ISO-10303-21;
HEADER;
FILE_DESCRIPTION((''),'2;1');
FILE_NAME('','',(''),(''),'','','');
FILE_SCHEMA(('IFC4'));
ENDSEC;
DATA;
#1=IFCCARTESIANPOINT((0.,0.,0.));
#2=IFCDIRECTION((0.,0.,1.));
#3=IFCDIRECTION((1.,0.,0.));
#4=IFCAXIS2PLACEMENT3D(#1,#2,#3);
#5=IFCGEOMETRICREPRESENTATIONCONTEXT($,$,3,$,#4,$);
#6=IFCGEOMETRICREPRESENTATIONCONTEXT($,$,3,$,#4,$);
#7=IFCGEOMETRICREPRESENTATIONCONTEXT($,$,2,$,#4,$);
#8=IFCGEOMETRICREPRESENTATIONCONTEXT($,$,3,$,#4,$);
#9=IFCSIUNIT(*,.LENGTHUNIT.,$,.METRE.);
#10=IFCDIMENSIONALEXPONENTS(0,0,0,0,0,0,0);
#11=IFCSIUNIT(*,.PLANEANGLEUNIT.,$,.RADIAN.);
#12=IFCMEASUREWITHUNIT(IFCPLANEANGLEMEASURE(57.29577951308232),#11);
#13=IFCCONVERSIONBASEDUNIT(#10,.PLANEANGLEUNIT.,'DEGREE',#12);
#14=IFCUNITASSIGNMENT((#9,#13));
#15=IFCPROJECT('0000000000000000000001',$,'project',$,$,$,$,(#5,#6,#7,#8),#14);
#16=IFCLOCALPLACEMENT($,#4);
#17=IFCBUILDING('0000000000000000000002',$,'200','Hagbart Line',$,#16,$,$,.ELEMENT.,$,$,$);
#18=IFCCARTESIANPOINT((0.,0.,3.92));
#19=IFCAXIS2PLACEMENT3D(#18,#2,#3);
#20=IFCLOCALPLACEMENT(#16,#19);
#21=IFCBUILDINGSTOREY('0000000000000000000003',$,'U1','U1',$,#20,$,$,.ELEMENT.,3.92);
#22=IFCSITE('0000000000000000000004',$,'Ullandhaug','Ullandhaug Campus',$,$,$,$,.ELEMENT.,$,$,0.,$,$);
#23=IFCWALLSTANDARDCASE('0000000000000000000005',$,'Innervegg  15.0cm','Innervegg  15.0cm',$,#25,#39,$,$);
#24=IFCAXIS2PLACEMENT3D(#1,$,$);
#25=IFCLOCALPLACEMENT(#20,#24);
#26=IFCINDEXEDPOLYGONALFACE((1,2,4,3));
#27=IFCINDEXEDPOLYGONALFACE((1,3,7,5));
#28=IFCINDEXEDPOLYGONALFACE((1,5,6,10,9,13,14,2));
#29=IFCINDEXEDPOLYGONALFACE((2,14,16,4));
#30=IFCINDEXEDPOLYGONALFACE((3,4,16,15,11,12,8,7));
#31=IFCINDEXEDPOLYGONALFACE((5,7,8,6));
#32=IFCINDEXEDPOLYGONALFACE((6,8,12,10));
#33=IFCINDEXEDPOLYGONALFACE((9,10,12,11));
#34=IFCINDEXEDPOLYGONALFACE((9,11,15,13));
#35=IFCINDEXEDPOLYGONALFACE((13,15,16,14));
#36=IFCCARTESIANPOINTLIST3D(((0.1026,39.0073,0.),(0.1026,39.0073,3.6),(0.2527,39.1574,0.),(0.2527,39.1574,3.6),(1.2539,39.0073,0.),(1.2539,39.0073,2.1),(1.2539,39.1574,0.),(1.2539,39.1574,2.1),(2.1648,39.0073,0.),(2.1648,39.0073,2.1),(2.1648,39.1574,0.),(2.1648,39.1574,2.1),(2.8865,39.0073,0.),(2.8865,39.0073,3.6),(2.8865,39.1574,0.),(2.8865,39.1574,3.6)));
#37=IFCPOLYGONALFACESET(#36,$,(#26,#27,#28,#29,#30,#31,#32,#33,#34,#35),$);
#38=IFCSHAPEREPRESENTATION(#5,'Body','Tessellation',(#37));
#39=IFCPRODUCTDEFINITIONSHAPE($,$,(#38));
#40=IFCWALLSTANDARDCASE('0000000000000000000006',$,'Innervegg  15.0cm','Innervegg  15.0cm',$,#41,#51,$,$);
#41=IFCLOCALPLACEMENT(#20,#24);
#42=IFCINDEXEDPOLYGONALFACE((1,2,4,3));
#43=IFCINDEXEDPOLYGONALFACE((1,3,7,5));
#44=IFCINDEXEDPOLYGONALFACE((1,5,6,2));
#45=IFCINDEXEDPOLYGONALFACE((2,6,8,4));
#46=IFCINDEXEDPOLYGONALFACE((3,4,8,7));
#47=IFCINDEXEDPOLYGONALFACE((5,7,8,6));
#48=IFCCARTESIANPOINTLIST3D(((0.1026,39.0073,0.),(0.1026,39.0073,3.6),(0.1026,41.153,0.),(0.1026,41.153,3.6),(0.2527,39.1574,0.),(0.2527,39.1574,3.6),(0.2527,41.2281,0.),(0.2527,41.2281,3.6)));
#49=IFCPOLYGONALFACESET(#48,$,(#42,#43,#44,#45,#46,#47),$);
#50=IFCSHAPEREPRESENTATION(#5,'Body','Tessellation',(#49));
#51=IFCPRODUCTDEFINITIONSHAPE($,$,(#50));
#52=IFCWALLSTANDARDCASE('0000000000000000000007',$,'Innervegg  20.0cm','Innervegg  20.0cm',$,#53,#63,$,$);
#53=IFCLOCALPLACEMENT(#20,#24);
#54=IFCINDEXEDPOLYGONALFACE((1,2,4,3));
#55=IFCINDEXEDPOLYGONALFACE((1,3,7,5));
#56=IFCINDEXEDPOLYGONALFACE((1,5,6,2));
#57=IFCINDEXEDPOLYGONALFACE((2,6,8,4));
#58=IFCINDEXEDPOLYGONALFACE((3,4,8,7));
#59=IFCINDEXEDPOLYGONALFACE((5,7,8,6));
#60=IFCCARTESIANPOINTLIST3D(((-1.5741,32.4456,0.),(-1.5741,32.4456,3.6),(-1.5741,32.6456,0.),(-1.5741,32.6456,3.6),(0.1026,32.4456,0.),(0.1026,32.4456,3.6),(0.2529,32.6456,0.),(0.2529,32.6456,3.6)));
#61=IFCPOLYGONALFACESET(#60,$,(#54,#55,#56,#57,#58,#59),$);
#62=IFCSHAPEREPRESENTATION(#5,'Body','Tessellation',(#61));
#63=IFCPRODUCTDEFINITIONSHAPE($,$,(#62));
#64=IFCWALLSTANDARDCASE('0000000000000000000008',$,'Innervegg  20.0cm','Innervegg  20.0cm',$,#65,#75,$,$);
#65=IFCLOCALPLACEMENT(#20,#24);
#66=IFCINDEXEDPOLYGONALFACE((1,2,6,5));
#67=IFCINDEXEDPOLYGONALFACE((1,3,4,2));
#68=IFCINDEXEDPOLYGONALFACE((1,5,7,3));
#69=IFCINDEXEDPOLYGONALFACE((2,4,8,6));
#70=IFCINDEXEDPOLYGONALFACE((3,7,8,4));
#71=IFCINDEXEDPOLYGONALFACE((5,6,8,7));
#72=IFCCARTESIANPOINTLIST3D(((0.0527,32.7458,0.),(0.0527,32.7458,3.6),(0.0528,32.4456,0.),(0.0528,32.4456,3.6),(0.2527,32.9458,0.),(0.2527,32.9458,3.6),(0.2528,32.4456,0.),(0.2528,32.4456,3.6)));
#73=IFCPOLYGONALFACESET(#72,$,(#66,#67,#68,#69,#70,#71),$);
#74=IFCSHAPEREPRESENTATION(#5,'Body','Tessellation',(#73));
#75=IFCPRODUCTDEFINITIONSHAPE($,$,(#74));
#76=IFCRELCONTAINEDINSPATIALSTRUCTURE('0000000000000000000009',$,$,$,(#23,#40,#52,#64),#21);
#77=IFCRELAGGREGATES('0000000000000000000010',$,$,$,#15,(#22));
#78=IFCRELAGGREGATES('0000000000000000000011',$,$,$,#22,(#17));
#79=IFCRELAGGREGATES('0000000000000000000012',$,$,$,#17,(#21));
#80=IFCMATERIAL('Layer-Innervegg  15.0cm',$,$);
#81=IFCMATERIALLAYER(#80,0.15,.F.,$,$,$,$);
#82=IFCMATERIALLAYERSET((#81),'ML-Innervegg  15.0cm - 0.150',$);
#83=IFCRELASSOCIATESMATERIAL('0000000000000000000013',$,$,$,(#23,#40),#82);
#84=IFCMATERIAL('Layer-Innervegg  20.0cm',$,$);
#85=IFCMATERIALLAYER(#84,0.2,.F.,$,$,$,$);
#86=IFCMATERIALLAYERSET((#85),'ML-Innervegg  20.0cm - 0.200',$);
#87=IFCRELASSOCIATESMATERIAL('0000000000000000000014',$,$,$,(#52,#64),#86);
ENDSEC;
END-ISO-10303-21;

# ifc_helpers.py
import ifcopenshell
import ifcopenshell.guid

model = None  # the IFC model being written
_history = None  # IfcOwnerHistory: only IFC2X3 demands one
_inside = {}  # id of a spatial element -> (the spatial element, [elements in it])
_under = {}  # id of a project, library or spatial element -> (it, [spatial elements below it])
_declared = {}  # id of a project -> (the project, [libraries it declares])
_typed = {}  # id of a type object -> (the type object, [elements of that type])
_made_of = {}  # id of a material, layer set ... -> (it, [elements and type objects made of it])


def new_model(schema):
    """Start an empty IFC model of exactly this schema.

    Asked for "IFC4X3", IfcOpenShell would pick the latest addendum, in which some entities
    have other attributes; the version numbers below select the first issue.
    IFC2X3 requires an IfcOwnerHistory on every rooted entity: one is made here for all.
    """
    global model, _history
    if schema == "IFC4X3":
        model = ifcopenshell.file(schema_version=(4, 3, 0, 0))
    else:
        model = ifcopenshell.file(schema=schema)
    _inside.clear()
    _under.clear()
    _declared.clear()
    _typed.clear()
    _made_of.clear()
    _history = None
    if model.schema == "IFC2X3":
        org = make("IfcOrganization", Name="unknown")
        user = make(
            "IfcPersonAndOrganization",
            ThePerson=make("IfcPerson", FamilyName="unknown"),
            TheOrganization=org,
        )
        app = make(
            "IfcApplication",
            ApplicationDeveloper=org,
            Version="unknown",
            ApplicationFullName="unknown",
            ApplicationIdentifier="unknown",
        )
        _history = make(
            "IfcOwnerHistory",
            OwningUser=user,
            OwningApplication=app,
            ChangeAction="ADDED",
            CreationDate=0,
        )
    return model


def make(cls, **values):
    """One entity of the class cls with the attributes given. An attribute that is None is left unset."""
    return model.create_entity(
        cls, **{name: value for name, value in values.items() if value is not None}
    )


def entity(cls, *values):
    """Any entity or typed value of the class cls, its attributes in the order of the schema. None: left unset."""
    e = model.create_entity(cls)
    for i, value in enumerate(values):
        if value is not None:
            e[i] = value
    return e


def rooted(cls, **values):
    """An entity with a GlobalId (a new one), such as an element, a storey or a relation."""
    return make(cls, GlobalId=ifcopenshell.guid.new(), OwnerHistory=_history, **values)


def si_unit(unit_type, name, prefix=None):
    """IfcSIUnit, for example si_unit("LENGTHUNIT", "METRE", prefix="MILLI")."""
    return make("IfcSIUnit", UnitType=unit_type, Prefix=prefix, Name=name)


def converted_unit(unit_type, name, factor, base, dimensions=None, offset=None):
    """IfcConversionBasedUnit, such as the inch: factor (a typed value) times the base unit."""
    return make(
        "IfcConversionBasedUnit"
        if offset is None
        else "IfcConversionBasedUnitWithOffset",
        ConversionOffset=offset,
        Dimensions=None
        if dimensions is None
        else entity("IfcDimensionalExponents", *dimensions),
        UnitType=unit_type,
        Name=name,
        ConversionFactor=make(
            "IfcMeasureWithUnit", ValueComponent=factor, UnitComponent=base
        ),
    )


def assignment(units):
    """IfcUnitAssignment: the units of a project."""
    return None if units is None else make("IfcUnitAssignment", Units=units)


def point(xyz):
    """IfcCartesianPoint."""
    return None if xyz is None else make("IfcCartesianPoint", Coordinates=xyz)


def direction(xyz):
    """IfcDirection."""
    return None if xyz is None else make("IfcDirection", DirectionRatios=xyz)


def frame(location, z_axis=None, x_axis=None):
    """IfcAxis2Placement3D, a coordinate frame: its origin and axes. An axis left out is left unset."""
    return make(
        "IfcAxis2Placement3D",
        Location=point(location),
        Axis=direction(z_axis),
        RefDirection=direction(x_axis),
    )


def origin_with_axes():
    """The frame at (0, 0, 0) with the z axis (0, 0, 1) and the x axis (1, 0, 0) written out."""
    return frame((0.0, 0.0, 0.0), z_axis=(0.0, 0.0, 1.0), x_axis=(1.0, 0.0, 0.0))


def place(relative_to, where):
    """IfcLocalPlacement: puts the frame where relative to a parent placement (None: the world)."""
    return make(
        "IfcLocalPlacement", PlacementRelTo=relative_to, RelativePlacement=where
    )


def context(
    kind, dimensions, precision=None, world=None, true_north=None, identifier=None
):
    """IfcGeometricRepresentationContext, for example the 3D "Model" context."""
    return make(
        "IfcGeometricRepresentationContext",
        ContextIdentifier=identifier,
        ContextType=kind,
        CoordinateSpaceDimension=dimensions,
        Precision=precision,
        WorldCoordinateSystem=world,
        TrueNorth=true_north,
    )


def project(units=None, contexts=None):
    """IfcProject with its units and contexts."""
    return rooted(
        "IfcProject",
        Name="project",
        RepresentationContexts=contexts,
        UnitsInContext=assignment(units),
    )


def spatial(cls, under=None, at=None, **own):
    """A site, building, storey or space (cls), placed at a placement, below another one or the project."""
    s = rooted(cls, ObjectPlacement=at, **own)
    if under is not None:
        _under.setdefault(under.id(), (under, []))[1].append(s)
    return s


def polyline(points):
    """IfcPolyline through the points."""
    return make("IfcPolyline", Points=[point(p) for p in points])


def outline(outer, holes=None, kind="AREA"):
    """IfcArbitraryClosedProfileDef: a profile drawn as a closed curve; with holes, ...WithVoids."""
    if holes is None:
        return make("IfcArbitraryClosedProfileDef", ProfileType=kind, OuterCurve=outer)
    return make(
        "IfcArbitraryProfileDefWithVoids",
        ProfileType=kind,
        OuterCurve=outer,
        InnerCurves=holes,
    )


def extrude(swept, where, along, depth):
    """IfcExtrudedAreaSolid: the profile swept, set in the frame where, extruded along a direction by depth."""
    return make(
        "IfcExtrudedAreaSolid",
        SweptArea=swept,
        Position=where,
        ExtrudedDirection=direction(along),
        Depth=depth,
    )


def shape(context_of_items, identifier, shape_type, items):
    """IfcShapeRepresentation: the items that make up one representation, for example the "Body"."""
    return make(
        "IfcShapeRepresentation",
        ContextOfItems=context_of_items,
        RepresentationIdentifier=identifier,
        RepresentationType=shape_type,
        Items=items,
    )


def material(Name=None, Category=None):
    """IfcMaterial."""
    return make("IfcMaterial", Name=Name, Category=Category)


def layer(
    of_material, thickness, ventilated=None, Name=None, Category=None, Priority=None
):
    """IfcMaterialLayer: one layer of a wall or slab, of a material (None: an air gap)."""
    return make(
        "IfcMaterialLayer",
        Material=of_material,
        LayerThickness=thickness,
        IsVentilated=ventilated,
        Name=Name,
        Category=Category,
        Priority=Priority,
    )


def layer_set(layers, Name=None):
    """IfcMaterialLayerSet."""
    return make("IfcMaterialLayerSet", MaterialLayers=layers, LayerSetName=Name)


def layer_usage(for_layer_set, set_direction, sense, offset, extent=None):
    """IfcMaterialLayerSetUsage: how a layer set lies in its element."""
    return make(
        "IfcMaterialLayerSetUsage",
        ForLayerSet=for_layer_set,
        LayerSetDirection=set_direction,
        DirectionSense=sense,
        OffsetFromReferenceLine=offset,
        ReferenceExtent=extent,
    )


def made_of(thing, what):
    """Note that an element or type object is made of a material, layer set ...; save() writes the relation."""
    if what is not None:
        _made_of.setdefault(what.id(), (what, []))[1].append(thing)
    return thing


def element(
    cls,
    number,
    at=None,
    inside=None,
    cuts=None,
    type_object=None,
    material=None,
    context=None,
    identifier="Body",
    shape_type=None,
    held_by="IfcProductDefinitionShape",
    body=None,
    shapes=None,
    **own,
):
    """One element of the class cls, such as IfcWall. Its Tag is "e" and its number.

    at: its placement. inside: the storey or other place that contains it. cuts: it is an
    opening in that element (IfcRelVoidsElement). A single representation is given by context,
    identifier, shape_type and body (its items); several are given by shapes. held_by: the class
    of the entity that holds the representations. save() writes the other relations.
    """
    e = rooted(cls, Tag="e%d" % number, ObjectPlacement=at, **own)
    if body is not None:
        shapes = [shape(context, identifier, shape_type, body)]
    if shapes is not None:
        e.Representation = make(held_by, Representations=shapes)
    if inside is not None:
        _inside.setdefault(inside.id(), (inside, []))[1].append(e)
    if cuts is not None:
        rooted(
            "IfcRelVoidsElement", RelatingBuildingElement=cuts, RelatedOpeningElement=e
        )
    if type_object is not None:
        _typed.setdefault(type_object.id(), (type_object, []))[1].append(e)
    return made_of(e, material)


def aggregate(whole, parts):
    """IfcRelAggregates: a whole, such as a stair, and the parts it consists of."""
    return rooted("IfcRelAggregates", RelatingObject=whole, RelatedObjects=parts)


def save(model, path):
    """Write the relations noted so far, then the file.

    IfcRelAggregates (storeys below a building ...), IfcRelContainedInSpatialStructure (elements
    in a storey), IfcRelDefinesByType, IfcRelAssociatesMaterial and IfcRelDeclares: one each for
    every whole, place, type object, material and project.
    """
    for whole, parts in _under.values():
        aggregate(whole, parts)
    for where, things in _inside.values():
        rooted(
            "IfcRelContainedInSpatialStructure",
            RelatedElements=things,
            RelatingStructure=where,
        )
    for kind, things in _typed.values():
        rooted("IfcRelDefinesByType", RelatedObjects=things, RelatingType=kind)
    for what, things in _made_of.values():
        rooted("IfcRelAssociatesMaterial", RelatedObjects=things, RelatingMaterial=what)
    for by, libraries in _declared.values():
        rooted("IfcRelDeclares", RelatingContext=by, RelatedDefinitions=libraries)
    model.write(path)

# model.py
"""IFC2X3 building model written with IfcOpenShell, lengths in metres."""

from ifc_helpers import new_model, entity, si_unit, converted_unit, frame, origin_with_axes, place, context, project, spatial, polyline, outline, extrude, material, layer, layer_set, layer_usage, element, save


model = new_model("IFC2X3")

# Units and contexts
context_of_model_1 = context(None, 3, world=origin_with_axes())
context_of_model_2 = context(None, 3, world=origin_with_axes())
context_of_model_3 = context(None, 2, world=origin_with_axes())
context_of_model_4 = context(None, 3, world=origin_with_axes())
ifc_project = project(units=[si_unit("LENGTHUNIT", "METRE"), converted_unit("PLANEANGLEUNIT", "DEGREE", entity("IfcPlaneAngleMeasure", 57.29577951308232), si_unit("PLANEANGLEUNIT", "RADIAN"), dimensions=[0, 0, 0, 0, 0, 0, 0])], contexts=[context_of_model_1, context_of_model_2, context_of_model_3, context_of_model_4])

# Site, building, storey
site = spatial("IfcSite", under=ifc_project, Name="Ullandhaug", Description="Ullandhaug Campus", CompositionType="ELEMENT", RefElevation=0.0)
building_placement = place(None, origin_with_axes())
building = spatial("IfcBuilding", under=site, at=building_placement, Name="200", Description="Hagbart Line", CompositionType="ELEMENT")
storey_placement = place(building_placement, frame((0.0, 0.0, 3.92), z_axis=(0.0, 0.0, 1.0), x_axis=(1.0, 0.0, 0.0)))
storey = spatial("IfcBuildingStorey", under=building, at=storey_placement, Name="U1", Description="U1", CompositionType="ELEMENT", Elevation=3.92)

# Shared definitions
ifc_material_1 = material(Name="Layer-Innervegg  15.0cm")
ifc_layer_1 = layer(ifc_material_1, 0.15, ventilated=False)
ifc_layer_set_1 = layer_set([ifc_layer_1], Name="ML-Innervegg  15.0cm - 0.150")
ifc_layer_usage_1 = layer_usage(ifc_layer_set_1, "AXIS2", "POSITIVE", 0.0)

# Wall, opening
wall_1_placement = place(storey_placement, frame((0.1026, 39.0073, 0.0), z_axis=(0.0, 0.0, 1.0), x_axis=(1.0, 0.0, 0.0)))
wall_1 = element("IfcWallStandardCase", 1, at=wall_1_placement, inside=storey, material=ifc_layer_usage_1, Name="Innervegg  15.0cm", Description="Innervegg  15.0cm", context=context_of_model_1, shape_type="SweptSolid", body=[
    extrude(outline(polyline([(0.0, 0.0), (2.7839, 0.0), (2.7839, 0.1502), (0.1502, 0.1502), (0.0, 0.0)])), origin_with_axes(), (0.0, 0.0, 1.0), 3.6),
])
opening_1_placement = place(wall_1_placement, frame((1.1513, 0.1502, 0.0), z_axis=(0.0, 0.0, 1.0), x_axis=(1.0, 0.0, 0.0)))
element("IfcOpeningElement", 2, at=opening_1_placement, cuts=wall_1, context=context_of_model_1, shape_type="SweptSolid", body=[
    extrude(outline(polyline([(0.0, 0.0), (2.1, 0.0), (2.1, 0.9109), (0.0, 0.9109), (0.0, 0.0)])), frame((0.0, 0.0, 0.0), z_axis=(0.0, 1.0, 0.0), x_axis=(0.0, 0.0, 1.0)), (0.0, 0.0, -1.0), 0.1502),
])

# Walls
wall_2_placement = place(storey_placement, frame((0.1026, 41.153, 0.0), z_axis=(0.0, 0.0, 1.0), x_axis=(0.0, -1.0, 0.0)))
element("IfcWallStandardCase", 3, at=wall_2_placement, inside=storey, material=ifc_layer_usage_1, Name="Innervegg  15.0cm", Description="Innervegg  15.0cm", context=context_of_model_1, shape_type="SweptSolid", body=[
    extrude(outline(polyline([(0.0, 0.0), (2.1457, 0.0), (1.9956, 0.1502), (-0.0751, 0.1502), (0.0, 0.0)])), frame((0.0, 0.0, 0.0), z_axis=(0.0, 0.0, 1.0), x_axis=(1.0, 0.0, 0.0)), (0.0, 0.0, 1.0), 3.6),
])
ifc_material_2 = material(Name="Layer-Innervegg  20.0cm")
ifc_layer_2 = layer(ifc_material_2, 0.2, ventilated=False)
ifc_layer_set_2 = layer_set([ifc_layer_2], Name="ML-Innervegg  20.0cm - 0.200")
ifc_layer_usage_2 = layer_usage(ifc_layer_set_2, "AXIS2", "POSITIVE", 0.0)
wall_3_placement = place(storey_placement, frame((0.2529, 32.6456, 0.0), z_axis=(0.0, 0.0, 1.0), x_axis=(-1.0, 0.0, 0.0)))
element("IfcWallStandardCase", 4, at=wall_3_placement, inside=storey, material=ifc_layer_usage_2, Name="Innervegg  20.0cm", Description="Innervegg  20.0cm", context=context_of_model_1, shape_type="SweptSolid", body=[
    extrude(outline(polyline([(0.0, 0.0), (1.827, 0.0), (1.827, 0.2), (0.1503, 0.2), (0.0, 0.0)])), frame((0.0, 0.0, 0.0), z_axis=(0.0, 0.0, 1.0), x_axis=(1.0, 0.0, 0.0)), (0.0, 0.0, 1.0), 3.6),
])
wall_4_placement = place(storey_placement, frame((0.0527, 32.7458, 0.0), z_axis=(0.0, 0.0, 1.0), x_axis=(0.000031, -1.0, 0.0)))
element("IfcWallStandardCase", 5, at=wall_4_placement, inside=storey, material=ifc_layer_usage_2, Name="Innervegg  20.0cm", Description="Innervegg  20.0cm", context=context_of_model_1, shape_type="SweptSolid", body=[
    extrude(outline(polyline([(0.0, 0.0), (0.3002, 0.0), (0.3002, 0.2), (-0.2, 0.2), (0.0, 0.0)])), frame((0.0, 0.0, 0.0), z_axis=(0.0, 0.0, 1.0), x_axis=(1.0, 0.0, 0.0)), (0.0, 0.0, 1.0), 3.6),
])

save(model, "model.ifc")
